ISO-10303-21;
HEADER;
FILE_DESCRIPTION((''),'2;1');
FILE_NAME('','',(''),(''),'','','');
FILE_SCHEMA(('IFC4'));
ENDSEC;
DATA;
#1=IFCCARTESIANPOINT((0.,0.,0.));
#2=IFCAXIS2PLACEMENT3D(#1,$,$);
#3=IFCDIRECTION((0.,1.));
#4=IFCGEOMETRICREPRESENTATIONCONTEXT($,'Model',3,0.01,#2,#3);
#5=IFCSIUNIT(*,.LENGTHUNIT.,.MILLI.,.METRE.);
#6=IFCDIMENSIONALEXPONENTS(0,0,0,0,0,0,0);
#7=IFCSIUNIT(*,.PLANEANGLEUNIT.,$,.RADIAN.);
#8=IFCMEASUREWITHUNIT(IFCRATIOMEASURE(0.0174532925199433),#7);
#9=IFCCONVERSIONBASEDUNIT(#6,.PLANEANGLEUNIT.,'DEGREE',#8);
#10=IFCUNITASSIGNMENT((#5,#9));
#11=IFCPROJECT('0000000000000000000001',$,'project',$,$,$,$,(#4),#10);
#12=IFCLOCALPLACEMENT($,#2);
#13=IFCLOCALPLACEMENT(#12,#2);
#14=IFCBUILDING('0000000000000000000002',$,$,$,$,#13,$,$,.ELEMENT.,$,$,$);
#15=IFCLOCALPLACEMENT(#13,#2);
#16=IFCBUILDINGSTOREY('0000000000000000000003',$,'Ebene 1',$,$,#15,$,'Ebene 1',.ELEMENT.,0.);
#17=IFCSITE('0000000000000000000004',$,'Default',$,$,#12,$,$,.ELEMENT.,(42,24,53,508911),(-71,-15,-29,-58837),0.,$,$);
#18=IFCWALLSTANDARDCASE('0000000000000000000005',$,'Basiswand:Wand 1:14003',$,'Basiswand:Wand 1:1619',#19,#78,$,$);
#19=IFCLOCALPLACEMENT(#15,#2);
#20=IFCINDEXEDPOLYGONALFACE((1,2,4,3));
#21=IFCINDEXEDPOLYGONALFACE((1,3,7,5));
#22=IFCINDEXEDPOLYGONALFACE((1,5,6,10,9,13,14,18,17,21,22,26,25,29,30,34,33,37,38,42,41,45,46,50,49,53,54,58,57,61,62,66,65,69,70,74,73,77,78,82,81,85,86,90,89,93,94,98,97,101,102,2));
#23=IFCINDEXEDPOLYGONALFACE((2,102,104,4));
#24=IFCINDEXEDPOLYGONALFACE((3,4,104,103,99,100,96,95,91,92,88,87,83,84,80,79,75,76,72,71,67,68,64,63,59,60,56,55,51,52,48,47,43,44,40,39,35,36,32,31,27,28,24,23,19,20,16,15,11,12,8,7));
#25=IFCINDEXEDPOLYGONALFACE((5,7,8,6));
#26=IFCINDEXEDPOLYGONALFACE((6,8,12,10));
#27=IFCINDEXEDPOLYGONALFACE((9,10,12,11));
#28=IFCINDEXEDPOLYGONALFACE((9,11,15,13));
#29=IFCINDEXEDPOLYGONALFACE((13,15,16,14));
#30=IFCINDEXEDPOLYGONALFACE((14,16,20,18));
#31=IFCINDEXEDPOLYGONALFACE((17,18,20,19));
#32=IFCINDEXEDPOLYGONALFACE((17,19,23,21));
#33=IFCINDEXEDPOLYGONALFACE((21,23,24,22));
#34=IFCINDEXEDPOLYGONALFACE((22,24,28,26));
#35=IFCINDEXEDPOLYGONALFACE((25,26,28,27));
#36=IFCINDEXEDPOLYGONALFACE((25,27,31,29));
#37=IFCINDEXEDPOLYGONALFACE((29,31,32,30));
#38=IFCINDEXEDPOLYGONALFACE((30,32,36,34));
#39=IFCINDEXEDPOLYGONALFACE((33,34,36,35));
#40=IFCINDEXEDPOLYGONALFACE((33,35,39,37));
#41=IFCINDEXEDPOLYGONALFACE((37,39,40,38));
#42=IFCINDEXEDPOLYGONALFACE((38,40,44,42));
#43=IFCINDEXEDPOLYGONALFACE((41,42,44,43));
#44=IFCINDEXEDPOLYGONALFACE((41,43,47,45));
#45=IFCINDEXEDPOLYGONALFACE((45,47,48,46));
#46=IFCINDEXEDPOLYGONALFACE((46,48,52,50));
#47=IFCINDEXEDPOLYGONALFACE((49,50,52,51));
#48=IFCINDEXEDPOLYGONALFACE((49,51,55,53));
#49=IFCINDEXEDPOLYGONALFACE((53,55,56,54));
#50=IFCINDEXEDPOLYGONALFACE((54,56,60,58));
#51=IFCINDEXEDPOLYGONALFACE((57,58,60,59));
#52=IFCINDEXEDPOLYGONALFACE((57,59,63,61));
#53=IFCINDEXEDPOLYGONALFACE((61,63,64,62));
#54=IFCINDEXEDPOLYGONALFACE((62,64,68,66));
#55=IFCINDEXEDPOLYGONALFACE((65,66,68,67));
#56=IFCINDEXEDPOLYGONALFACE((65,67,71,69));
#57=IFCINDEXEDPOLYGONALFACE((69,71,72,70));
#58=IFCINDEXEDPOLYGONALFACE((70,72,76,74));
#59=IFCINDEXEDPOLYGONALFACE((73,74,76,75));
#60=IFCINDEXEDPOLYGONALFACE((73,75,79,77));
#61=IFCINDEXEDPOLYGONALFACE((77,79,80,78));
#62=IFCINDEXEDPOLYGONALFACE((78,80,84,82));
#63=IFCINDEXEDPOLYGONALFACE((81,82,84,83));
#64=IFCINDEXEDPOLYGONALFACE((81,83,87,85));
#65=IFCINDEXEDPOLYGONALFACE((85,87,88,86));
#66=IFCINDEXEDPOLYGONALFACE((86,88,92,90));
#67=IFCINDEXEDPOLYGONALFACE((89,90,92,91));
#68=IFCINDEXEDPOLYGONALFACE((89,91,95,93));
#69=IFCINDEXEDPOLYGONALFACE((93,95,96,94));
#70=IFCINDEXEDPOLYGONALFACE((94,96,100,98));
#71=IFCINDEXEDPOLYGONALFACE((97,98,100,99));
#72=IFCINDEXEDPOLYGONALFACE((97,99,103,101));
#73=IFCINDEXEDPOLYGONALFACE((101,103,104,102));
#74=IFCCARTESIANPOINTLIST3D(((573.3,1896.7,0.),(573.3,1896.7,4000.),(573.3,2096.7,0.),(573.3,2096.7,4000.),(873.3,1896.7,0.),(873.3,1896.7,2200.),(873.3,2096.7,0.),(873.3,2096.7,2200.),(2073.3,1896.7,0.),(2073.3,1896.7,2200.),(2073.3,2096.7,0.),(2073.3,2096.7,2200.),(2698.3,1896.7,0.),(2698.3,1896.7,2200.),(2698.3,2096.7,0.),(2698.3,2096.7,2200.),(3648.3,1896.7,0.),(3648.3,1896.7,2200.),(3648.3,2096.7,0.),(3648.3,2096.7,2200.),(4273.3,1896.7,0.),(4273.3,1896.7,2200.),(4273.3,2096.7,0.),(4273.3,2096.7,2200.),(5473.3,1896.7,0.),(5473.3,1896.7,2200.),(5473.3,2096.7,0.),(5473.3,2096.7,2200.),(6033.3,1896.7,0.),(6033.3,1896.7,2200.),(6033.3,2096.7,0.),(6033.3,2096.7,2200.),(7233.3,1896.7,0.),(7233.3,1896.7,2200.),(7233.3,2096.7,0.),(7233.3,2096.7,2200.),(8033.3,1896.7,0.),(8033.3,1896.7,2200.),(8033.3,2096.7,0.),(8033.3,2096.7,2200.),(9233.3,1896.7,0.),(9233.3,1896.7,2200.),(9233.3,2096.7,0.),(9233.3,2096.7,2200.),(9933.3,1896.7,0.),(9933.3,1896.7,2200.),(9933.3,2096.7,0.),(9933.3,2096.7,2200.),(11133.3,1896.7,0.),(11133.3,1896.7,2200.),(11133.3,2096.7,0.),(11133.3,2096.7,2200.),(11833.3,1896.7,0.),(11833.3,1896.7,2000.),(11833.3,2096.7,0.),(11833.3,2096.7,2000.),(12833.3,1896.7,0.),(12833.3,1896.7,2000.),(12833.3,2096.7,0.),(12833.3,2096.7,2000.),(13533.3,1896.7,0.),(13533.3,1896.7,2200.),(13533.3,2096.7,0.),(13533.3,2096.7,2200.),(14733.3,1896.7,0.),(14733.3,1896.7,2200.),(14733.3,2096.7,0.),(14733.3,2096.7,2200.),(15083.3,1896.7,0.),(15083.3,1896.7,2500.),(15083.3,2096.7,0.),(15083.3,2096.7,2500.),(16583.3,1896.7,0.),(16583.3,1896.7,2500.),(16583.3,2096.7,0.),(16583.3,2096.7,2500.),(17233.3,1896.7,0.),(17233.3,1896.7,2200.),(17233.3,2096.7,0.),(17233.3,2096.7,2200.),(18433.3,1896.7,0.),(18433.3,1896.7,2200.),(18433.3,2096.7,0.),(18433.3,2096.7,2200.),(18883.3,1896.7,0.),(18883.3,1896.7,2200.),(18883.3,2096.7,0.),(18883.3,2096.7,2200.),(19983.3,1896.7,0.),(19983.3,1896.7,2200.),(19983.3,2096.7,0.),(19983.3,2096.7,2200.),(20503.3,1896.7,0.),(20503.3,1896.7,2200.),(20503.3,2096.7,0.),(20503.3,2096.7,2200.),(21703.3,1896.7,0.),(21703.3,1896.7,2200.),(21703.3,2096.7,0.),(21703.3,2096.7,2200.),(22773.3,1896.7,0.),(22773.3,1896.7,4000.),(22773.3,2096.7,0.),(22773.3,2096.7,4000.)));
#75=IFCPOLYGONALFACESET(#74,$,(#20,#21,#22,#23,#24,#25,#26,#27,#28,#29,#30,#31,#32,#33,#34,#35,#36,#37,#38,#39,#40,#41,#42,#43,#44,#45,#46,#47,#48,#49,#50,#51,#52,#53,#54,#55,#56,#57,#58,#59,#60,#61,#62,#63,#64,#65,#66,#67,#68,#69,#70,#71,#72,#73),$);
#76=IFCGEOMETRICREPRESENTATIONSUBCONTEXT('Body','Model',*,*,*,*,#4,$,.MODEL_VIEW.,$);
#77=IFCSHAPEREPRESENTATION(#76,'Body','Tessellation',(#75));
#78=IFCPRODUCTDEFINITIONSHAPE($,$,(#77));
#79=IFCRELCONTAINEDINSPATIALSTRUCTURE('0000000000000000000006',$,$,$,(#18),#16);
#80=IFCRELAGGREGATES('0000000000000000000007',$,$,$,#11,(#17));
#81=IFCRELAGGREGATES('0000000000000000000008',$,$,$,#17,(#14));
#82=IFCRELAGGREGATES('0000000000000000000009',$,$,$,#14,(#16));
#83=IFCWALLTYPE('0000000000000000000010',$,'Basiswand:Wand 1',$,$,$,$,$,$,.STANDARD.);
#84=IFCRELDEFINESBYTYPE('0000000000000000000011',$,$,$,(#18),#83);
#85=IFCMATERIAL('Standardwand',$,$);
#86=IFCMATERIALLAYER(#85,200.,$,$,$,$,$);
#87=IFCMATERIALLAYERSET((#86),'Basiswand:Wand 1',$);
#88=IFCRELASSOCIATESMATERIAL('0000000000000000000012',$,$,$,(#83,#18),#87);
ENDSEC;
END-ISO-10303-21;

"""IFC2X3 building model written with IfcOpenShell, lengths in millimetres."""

from ifc_helpers import new_model, entity, si_unit, converted_unit, direction, frame, frame_2d, origin, place, context, subcontext, project, spatial, rectangle, extrude, material, layer, layer_set, layer_usage, type_object, element, save


model = new_model("IFC2X3")

# Units and contexts
model_context = context("Model", 3, precision=0.01, world=origin(), true_north=direction((0.0, 1.0)))
body_context = subcontext(model_context, "Body", "Model", "MODEL_VIEW")
ifc_project = project(units=[si_unit("LENGTHUNIT", "METRE", prefix="MILLI"), converted_unit("PLANEANGLEUNIT", "DEGREE", entity("IfcRatioMeasure", 0.0174532925199433), si_unit("PLANEANGLEUNIT", "RADIAN"), dimensions=[0, 0, 0, 0, 0, 0, 0])], contexts=[model_context])

# Site, building, storey
site_placement = place(None, origin())
site = spatial("IfcSite", under=ifc_project, at=site_placement, Name="Default", CompositionType="ELEMENT", RefLatitude=(42, 24, 53, 508911), RefLongitude=(-71, -15, -29, -58837), RefElevation=0.0)
building_placement = place(site_placement, origin())
building = spatial("IfcBuilding", under=site, at=building_placement, CompositionType="ELEMENT")
storey_placement = place(building_placement, origin())
storey = spatial("IfcBuildingStorey", under=building, at=storey_placement, Name="Ebene 1", LongName="Ebene 1", CompositionType="ELEMENT", Elevation=0.0)

# Wall, openings
ifc_material = material(Name="Standardwand")
ifc_layer = layer(ifc_material, 200.0)
ifc_layer_set = layer_set([ifc_layer], Name="Basiswand:Wand 1")
ifc_layer_usage = layer_usage(ifc_layer_set, "AXIS2", "NEGATIVE", 100.0)
wall_type = type_object("IfcWallType", Name="Basiswand:Wand 1", PredefinedType="STANDARD", material=ifc_layer_set)
wall_placement = place(storey_placement, frame((573.3, 1996.7, 0.0)))
wall = element("IfcWallStandardCase", 1, at=wall_placement, inside=storey, type_object=wall_type, material=ifc_layer_usage, Name="Basiswand:Wand 1:14003", ObjectType="Basiswand:Wand 1:1619", context=body_context, shape_type="SweptSolid", body=[
    extrude(rectangle(XDim=22200.0, YDim=200.0, at=frame_2d((11100.0, 0.0), x_axis=(-1.0, 0.0))), origin(), (0.0, 0.0, 1.0), 4000.0),
])
opening_1_placement = place(wall_placement, frame((300.0, -100.0, 0.0)))
element("IfcOpeningElement", 2, at=opening_1_placement, cuts=wall, ObjectType="Opening", context=body_context, shape_type="SweptSolid", body=[
    extrude(rectangle(XDim=2200.0, YDim=1200.0, at=frame_2d((1100.0, 600.0), x_axis=(-1.0, 0.0))), frame((0.0, 0.0, 0.0), z_axis=(0.0, 1.0, 0.0), x_axis=(0.0, 0.0, 1.0)), (0.0, 0.0, 1.0), 200.0),
])
opening_2_placement = place(wall_placement, frame((2125.0, -100.0, 0.0)))
element("IfcOpeningElement", 3, at=opening_2_placement, cuts=wall, ObjectType="Opening", context=body_context, shape_type="SweptSolid", body=[
    extrude(rectangle(XDim=2200.0, YDim=950.0, at=frame_2d((1100.0, 475.0), x_axis=(-1.0, 0.0))), frame((0.0, 0.0, 0.0), z_axis=(0.0, 1.0, 0.0), x_axis=(0.0, 0.0, 1.0)), (0.0, 0.0, 1.0), 200.0),
])
opening_3_placement = place(wall_placement, frame((3700.0, -100.0, 0.0)))
element("IfcOpeningElement", 4, at=opening_3_placement, cuts=wall, ObjectType="Opening", context=body_context, shape_type="SweptSolid", body=[
    extrude(rectangle(XDim=2200.0, YDim=1200.0, at=frame_2d((1100.0, 600.0), x_axis=(-1.0, 0.0))), frame((0.0, 0.0, 0.0), z_axis=(0.0, 1.0, 0.0), x_axis=(0.0, 0.0, 1.0)), (0.0, 0.0, 1.0), 200.0),
])
opening_4_placement = place(wall_placement, frame((5460.0, -100.0, 0.0)))
element("IfcOpeningElement", 5, at=opening_4_placement, cuts=wall, ObjectType="Opening", context=body_context, shape_type="SweptSolid", body=[
    extrude(rectangle(XDim=2200.0, YDim=1200.0, at=frame_2d((1100.0, 600.0), x_axis=(-1.0, 0.0))), frame((0.0, 0.0, 0.0), z_axis=(0.0, 1.0, 0.0), x_axis=(0.0, 0.0, 1.0)), (0.0, 0.0, 1.0), 200.0),
])
opening_5_placement = place(wall_placement, frame((7460.0, -100.0, 0.0)))
element("IfcOpeningElement", 6, at=opening_5_placement, cuts=wall, ObjectType="Opening", context=body_context, shape_type="SweptSolid", body=[
    extrude(rectangle(XDim=2200.0, YDim=1200.0, at=frame_2d((1100.0, 600.0), x_axis=(-1.0, 0.0))), frame((0.0, 0.0, 0.0), z_axis=(0.0, 1.0, 0.0), x_axis=(0.0, 0.0, 1.0)), (0.0, 0.0, 1.0), 200.0),
])
opening_6_placement = place(wall_placement, frame((10560.0, 100.0, 0.0)))
element("IfcOpeningElement", 7, at=opening_6_placement, cuts=wall, ObjectType="Opening", context=body_context, shape_type="SweptSolid", body=[
    extrude(rectangle(XDim=2200.0, YDim=1200.0, at=frame_2d((1100.0, 600.0), x_axis=(-1.0, 0.0))), frame((0.0, 0.0, 0.0), z_axis=(0.0, -1.0, 0.0), x_axis=(0.0, 0.0, 1.0)), (0.0, 0.0, 1.0), 200.0),
])
opening_7_placement = place(wall_placement, frame((12260.0, 100.0, 0.0)))
element("IfcOpeningElement", 8, at=opening_7_placement, cuts=wall, ObjectType="Opening", context=body_context, shape_type="SweptSolid", body=[
    extrude(rectangle(XDim=2000.0, YDim=1000.0, at=frame_2d((1000.0, 500.0), x_axis=(-1.0, 0.0))), frame((0.0, 0.0, 0.0), z_axis=(0.0, -1.0, 0.0), x_axis=(0.0, 0.0, 1.0)), (0.0, 0.0, 1.0), 200.0),
])
opening_8_placement = place(wall_placement, frame((12960.0, -100.0, 0.0)))
element("IfcOpeningElement", 9, at=opening_8_placement, cuts=wall, ObjectType="Opening", context=body_context, shape_type="SweptSolid", body=[
    extrude(rectangle(XDim=2200.0, YDim=1200.0, at=frame_2d((1100.0, 600.0), x_axis=(-1.0, 0.0))), frame((0.0, 0.0, 0.0), z_axis=(0.0, 1.0, 0.0), x_axis=(0.0, 0.0, 1.0)), (0.0, 0.0, 1.0), 200.0),
])
opening_9_placement = place(wall_placement, frame((14510.0, -100.0, 0.0)))
element("IfcOpeningElement", 10, at=opening_9_placement, cuts=wall, ObjectType="Opening", context=body_context, shape_type="SweptSolid", body=[
    extrude(rectangle(XDim=2500.0, YDim=1500.0, at=frame_2d((1250.0, 750.0), x_axis=(-1.0, 0.0))), frame((0.0, 0.0, 0.0), z_axis=(0.0, 1.0, 0.0), x_axis=(0.0, 0.0, 1.0)), (0.0, 0.0, 1.0), 200.0),
])
opening_10_placement = place(wall_placement, frame((16660.0, -100.0, 0.0)))
element("IfcOpeningElement", 11, at=opening_10_placement, cuts=wall, ObjectType="Opening", context=body_context, shape_type="SweptSolid", body=[
    extrude(rectangle(XDim=2200.0, YDim=1200.0, at=frame_2d((1100.0, 600.0), x_axis=(-1.0, 0.0))), frame((0.0, 0.0, 0.0), z_axis=(0.0, 1.0, 0.0), x_axis=(0.0, 0.0, 1.0)), (0.0, 0.0, 1.0), 200.0),
])
opening_11_placement = place(wall_placement, frame((19410.0, 100.0, 0.0)))
element("IfcOpeningElement", 12, at=opening_11_placement, cuts=wall, ObjectType="Opening", context=body_context, shape_type="SweptSolid", body=[
    extrude(rectangle(XDim=2200.0, YDim=1100.0, at=frame_2d((1100.0, 550.0), x_axis=(-1.0, 0.0))), frame((0.0, 0.0, 0.0), z_axis=(0.0, -1.0, 0.0), x_axis=(0.0, 0.0, 1.0)), (0.0, 0.0, 1.0), 200.0),
])
opening_12_placement = place(wall_placement, frame((21130.0, 100.0, 0.0)))
element("IfcOpeningElement", 13, at=opening_12_placement, cuts=wall, ObjectType="Opening", context=body_context, shape_type="SweptSolid", body=[
    extrude(rectangle(XDim=2200.0, YDim=1200.0, at=frame_2d((1100.0, 600.0), x_axis=(-1.0, 0.0))), frame((0.0, 0.0, 0.0), z_axis=(0.0, -1.0, 0.0), x_axis=(0.0, 0.0, 1.0)), (0.0, 0.0, 1.0), 200.0),
])

save(model, "model.ifc")
